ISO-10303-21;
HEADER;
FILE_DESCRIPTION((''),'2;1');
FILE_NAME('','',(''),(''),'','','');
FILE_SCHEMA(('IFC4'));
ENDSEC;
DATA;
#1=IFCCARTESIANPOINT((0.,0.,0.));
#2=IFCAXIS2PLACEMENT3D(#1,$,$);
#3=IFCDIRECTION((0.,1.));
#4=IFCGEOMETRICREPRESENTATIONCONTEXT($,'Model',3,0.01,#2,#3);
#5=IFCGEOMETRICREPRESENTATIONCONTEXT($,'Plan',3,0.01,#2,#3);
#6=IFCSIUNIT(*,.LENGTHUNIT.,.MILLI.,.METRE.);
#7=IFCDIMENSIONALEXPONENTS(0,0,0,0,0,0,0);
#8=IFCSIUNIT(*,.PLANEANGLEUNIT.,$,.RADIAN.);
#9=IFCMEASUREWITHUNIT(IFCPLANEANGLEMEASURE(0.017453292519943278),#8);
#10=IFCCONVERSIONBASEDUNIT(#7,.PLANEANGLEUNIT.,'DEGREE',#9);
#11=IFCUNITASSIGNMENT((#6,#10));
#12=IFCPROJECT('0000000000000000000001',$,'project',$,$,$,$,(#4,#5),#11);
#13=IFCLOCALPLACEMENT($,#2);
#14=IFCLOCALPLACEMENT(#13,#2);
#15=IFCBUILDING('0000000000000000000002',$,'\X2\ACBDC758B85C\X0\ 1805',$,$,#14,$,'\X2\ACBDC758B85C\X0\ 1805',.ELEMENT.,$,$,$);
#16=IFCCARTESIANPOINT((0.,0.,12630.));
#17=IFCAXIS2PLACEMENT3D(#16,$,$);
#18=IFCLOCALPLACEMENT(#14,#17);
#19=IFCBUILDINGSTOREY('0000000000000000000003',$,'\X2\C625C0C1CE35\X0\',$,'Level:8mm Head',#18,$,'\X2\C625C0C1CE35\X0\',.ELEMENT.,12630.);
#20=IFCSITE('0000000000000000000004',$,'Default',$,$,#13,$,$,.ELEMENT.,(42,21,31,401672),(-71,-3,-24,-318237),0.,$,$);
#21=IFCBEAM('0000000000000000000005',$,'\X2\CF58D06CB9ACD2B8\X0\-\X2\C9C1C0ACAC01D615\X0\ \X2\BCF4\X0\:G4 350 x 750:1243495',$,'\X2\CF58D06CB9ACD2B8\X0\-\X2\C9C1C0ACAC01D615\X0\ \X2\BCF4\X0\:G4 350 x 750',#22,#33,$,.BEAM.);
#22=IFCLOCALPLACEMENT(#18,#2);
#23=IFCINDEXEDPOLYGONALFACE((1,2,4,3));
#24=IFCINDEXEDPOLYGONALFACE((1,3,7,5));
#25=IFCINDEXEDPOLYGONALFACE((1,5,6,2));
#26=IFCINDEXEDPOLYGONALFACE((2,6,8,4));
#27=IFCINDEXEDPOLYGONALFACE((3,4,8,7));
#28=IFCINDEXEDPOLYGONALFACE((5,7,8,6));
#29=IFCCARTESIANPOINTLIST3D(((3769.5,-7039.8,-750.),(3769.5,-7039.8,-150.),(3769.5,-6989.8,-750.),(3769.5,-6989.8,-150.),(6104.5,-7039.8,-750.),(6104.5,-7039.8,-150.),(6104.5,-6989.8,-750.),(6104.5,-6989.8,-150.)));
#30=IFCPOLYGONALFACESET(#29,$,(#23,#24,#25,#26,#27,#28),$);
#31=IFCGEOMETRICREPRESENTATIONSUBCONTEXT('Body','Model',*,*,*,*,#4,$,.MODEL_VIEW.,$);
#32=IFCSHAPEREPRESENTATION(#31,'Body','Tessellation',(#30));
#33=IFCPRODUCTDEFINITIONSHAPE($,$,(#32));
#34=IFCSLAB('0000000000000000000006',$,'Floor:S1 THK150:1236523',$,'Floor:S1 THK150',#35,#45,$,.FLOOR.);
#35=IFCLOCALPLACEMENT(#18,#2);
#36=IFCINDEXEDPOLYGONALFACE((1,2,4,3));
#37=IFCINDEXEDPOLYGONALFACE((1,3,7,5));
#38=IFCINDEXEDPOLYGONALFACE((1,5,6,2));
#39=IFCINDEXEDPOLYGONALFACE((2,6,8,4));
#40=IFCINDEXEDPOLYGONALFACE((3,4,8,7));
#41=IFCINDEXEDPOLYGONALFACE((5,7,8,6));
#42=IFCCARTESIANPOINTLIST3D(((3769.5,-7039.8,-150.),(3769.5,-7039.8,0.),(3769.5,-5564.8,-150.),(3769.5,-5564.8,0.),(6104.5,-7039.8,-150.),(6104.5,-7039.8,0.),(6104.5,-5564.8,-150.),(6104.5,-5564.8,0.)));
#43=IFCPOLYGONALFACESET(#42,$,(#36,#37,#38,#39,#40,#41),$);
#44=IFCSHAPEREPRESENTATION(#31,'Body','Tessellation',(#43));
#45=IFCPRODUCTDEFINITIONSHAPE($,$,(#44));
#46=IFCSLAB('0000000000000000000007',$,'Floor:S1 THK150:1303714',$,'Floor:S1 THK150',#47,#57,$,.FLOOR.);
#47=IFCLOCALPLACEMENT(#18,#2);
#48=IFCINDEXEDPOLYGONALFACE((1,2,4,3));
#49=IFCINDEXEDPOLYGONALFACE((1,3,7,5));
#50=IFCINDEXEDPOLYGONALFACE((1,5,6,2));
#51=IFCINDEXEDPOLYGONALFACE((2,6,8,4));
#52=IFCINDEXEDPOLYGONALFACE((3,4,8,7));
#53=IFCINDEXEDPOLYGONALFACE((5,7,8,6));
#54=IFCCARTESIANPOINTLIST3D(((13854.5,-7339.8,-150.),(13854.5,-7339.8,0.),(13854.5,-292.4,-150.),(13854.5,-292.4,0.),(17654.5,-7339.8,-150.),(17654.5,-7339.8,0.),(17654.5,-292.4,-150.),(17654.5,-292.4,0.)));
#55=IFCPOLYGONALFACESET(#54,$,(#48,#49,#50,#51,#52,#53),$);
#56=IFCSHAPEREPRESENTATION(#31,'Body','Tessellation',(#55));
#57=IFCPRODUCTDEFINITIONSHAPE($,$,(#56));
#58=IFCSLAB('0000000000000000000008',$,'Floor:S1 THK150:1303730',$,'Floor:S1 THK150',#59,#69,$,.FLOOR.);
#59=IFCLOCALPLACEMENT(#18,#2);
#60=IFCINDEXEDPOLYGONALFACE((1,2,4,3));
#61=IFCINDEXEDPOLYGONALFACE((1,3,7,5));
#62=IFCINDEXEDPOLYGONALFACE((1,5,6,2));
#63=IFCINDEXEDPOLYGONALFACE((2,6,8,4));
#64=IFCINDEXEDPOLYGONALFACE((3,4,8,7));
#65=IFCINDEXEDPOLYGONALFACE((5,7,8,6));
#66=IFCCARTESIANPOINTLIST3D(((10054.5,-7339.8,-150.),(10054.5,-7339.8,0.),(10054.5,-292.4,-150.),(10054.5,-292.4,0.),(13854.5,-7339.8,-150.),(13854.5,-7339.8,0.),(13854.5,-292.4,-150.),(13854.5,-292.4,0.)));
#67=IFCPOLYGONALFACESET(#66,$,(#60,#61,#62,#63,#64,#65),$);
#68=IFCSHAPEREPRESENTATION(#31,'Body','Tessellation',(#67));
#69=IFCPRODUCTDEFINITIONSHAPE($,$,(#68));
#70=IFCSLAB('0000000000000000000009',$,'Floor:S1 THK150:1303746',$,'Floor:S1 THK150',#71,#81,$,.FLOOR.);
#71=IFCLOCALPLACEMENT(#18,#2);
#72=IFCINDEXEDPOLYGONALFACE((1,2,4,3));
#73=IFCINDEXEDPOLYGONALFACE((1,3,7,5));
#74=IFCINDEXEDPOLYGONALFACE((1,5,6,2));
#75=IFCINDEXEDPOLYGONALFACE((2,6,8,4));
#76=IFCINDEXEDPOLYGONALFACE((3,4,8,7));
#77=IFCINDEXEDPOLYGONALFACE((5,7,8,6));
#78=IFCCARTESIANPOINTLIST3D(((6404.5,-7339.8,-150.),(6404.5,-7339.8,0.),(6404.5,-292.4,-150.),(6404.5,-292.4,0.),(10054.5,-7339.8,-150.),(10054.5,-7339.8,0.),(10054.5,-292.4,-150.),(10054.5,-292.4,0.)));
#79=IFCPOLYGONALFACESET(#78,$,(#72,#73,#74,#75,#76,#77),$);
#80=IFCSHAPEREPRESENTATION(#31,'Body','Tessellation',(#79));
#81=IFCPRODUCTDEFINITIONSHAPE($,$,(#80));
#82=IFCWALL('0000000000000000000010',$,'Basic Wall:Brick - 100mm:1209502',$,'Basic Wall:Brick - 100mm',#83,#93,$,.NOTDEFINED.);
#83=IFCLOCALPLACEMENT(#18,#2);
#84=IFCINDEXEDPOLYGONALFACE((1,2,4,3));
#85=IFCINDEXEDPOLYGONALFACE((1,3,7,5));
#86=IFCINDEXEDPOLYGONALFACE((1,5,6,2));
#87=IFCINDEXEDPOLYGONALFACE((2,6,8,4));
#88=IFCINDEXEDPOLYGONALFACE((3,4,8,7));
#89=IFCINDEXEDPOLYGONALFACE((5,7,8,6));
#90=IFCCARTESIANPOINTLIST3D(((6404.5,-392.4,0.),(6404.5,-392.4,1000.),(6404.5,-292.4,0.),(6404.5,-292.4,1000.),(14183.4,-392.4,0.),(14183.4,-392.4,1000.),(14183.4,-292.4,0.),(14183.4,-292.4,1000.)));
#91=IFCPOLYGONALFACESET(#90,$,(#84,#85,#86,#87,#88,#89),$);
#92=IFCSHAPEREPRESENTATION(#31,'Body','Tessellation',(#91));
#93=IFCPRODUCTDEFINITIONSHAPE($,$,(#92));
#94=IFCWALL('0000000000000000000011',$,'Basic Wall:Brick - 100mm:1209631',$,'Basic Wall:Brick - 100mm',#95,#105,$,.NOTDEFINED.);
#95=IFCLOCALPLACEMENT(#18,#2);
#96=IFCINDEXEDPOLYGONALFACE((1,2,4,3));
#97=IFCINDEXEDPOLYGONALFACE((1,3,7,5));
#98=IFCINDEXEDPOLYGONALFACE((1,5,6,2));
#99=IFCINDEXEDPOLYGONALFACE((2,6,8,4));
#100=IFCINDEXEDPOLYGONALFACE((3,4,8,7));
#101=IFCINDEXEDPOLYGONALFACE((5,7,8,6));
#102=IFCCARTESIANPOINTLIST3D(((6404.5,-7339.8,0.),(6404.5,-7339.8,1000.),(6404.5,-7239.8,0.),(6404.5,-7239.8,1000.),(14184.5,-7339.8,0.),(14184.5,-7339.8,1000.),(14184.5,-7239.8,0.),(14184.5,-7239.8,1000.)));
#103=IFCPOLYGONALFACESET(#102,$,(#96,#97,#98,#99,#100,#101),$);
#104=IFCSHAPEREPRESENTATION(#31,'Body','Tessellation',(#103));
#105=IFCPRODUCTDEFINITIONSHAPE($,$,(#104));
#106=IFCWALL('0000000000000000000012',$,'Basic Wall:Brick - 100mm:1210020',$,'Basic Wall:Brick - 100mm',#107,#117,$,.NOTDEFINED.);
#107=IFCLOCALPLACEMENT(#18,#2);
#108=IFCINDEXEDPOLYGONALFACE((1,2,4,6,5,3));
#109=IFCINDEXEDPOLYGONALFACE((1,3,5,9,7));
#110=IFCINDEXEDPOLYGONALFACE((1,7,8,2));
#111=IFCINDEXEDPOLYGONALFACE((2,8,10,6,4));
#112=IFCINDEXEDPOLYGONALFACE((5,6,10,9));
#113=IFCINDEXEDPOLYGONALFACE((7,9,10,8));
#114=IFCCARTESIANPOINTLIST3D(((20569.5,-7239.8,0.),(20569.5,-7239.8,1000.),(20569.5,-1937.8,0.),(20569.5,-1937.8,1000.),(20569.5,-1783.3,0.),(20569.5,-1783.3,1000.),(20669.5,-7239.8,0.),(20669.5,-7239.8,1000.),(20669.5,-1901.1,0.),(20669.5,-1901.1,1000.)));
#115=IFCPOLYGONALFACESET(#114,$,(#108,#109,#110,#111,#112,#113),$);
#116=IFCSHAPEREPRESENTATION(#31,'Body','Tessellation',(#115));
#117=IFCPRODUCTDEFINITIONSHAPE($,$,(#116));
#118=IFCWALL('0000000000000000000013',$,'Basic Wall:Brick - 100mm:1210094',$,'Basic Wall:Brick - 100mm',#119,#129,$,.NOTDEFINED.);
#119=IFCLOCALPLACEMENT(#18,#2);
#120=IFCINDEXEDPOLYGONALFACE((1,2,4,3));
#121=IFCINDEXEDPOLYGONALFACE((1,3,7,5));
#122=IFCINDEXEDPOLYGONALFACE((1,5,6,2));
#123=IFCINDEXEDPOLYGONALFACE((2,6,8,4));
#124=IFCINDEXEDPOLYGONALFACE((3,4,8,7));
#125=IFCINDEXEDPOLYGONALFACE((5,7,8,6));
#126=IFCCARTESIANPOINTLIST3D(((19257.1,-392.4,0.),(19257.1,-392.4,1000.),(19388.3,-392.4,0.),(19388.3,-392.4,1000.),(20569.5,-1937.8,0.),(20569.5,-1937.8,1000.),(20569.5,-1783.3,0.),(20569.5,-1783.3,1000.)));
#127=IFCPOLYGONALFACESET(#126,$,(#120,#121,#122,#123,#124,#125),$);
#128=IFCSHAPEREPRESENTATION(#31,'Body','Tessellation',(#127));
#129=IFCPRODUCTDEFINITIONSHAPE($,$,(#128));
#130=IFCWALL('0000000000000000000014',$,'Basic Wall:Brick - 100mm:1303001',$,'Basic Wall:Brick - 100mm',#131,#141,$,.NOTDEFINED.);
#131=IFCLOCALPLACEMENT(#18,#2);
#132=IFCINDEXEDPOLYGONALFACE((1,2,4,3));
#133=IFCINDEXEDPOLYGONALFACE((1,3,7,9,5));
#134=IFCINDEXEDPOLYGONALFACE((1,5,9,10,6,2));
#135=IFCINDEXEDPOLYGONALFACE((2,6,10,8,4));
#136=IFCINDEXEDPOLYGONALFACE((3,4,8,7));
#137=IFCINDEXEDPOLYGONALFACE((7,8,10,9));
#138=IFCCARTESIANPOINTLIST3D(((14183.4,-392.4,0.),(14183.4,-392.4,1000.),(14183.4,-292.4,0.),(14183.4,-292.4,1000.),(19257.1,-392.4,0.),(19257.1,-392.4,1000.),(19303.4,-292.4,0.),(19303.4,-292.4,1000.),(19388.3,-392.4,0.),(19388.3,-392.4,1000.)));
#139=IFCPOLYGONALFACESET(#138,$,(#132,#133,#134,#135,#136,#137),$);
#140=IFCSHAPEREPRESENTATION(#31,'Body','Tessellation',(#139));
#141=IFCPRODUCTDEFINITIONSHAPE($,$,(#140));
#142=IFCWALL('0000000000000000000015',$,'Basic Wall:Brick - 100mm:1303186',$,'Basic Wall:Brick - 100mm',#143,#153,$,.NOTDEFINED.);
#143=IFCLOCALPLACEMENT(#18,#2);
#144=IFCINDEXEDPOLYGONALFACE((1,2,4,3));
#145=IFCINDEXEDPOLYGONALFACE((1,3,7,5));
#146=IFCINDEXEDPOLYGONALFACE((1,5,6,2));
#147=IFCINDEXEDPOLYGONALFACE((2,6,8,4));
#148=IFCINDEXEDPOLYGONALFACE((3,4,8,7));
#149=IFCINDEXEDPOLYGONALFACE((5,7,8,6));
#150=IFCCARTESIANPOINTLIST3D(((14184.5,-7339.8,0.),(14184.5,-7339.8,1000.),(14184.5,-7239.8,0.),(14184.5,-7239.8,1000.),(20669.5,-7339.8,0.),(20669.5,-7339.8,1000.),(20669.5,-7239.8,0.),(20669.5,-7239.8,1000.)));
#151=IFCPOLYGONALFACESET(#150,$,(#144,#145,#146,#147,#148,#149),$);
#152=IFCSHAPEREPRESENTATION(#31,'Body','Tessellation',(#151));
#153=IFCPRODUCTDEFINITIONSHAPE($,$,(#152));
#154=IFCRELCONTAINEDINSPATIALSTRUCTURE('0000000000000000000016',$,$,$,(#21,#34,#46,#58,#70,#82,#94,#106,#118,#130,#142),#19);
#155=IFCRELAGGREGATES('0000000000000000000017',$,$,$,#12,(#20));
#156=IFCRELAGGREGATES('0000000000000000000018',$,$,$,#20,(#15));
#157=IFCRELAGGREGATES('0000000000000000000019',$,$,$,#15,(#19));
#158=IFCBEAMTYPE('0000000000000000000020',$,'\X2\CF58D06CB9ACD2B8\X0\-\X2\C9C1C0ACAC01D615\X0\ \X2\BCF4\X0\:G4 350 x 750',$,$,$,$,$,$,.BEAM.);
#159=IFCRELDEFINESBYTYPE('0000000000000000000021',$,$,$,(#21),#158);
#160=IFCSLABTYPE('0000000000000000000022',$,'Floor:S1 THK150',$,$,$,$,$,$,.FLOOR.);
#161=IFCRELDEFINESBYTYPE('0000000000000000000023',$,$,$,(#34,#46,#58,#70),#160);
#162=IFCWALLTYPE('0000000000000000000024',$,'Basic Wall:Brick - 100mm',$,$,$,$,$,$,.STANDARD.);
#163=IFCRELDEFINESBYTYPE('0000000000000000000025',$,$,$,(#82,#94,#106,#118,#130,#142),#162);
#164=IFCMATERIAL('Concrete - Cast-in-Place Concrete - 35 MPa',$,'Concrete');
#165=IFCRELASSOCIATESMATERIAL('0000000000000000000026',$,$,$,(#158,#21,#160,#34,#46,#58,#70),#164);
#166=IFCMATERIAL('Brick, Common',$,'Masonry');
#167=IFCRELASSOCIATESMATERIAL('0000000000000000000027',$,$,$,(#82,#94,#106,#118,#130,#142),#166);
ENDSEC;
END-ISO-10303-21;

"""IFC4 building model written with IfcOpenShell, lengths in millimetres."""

from ifc_helpers import new_model, entity, si_unit, converted_unit, direction, frame, origin, place, context, subcontext, project, spatial, indexed_curve, outline, extrude, source, transform, mapped, material, type_object, type_shapes, element, save


model = new_model("IFC4")

# Units and contexts
model_context = context("Model", 3, precision=0.01, world=origin(), true_north=direction((0.0, 1.0)))
plan_context = context("Plan", 3, precision=0.01, world=origin(), true_north=direction((0.0, 1.0)))
body_context = subcontext(model_context, "Body", "Model", "MODEL_VIEW")
ifc_project = project(units=[si_unit("LENGTHUNIT", "METRE", prefix="MILLI"), converted_unit("PLANEANGLEUNIT", "DEGREE", entity("IfcPlaneAngleMeasure", 0.017453292519943278), si_unit("PLANEANGLEUNIT", "RADIAN"), dimensions=[0, 0, 0, 0, 0, 0, 0])], contexts=[model_context, plan_context])

# Site, building, storey
site_placement = place(None, origin())
site = spatial("IfcSite", under=ifc_project, at=site_placement, Name="Default", CompositionType="ELEMENT", RefLatitude=(42, 21, 31, 401672), RefLongitude=(-71, -3, -24, -318237), RefElevation=0.0)
building_placement = place(site_placement, origin())
building = spatial("IfcBuilding", under=site, at=building_placement, Name="경의로 1805", LongName="경의로 1805", CompositionType="ELEMENT")
storey_placement = place(building_placement, frame((0.0, 0.0, 12630.0)))
storey = spatial("IfcBuildingStorey", under=building, at=storey_placement, Name="옥상층", ObjectType="Level:8mm Head", LongName="옥상층", CompositionType="ELEMENT", Elevation=12630.0)

# Beam
ifc_material_1 = material(Name="Concrete - Cast-in-Place Concrete - 35 MPa", Category="Concrete")
beam_type = type_object("IfcBeamType", Name="콘크리트-직사각형 보:G4 350 x 750", PredefinedType="BEAM", material=ifc_material_1)
shared_shape = source(origin(), body_context, "Body", "SweptSolid", [
    extrude(outline(indexed_curve([(-300.0, -25.0), (300.0, -25.0), (300.0, 25.0), (-300.0, 25.0), (-300.0, -25.0)], self_intersect=False)), frame((3769.5, -7014.8, 12180.0), z_axis=(1.0, 0.0, 0.0), x_axis=(0.0, 0.0, -1.0)), (0.0, 0.0, 1.0), 2335.0),
])
type_shapes(beam_type, [shared_shape])
beam_placement = place(storey_placement, frame((0.0, 0.0, -12630.0)))
element("IfcBeam", 1, at=beam_placement, inside=storey, type_object=beam_type, material=ifc_material_1, Name="콘크리트-직사각형 보:G4 350 x 750:1243495", ObjectType="콘크리트-직사각형 보:G4 350 x 750", PredefinedType="BEAM", context=body_context, shape_type="MappedRepresentation", body=[
    mapped(shared_shape, transform((0.0, 0.0, 0.0), scale=1.0)),
])

# Slabs
slab_type = type_object("IfcSlabType", Name="Floor:S1 THK150", PredefinedType="FLOOR", material=ifc_material_1)
slab_1_placement = place(storey_placement, origin())
element("IfcSlab", 2, at=slab_1_placement, inside=storey, type_object=slab_type, material=ifc_material_1, Name="Floor:S1 THK150:1236523", ObjectType="Floor:S1 THK150", PredefinedType="FLOOR", context=body_context, shape_type="SweptSolid", body=[
    extrude(outline(indexed_curve([(-737.5, -1167.5), (737.5, -1167.5), (737.5, 1167.5), (-737.5, 1167.5), (-737.5, -1167.5)], self_intersect=False)), frame((4937.0, -6302.3, 0.0), z_axis=(0.0, 0.0, -1.0), x_axis=(0.0, 1.0, 0.0)), (0.0, 0.0, 1.0), 150.0),
])
slab_2_placement = place(storey_placement, origin())
element("IfcSlab", 3, at=slab_2_placement, inside=storey, type_object=slab_type, material=ifc_material_1, Name="Floor:S1 THK150:1303714", ObjectType="Floor:S1 THK150", PredefinedType="FLOOR", context=body_context, shape_type="SweptSolid", body=[
    extrude(outline(indexed_curve([(-3523.7, -1900.0), (3523.7, -1900.0), (3523.7, 1900.0), (-3523.7, 1900.0), (-3523.7, -1900.0)], self_intersect=False)), frame((15754.5, -3816.1, 0.0), z_axis=(0.0, 0.0, -1.0), x_axis=(0.0, 1.0, 0.0)), (0.0, 0.0, 1.0), 150.0),
])
slab_3_placement = place(storey_placement, origin())
element("IfcSlab", 4, at=slab_3_placement, inside=storey, type_object=slab_type, material=ifc_material_1, Name="Floor:S1 THK150:1303730", ObjectType="Floor:S1 THK150", PredefinedType="FLOOR", context=body_context, shape_type="SweptSolid", body=[
    extrude(outline(indexed_curve([(-3523.7, -1900.0), (3523.7, -1900.0), (3523.7, 1900.0), (-3523.7, 1900.0), (-3523.7, -1900.0)], self_intersect=False)), frame((11954.5, -3816.1, 0.0), z_axis=(0.0, 0.0, -1.0), x_axis=(0.0, 1.0, 0.0)), (0.0, 0.0, 1.0), 150.0),
])
slab_4_placement = place(storey_placement, origin())
element("IfcSlab", 5, at=slab_4_placement, inside=storey, type_object=slab_type, material=ifc_material_1, Name="Floor:S1 THK150:1303746", ObjectType="Floor:S1 THK150", PredefinedType="FLOOR", context=body_context, shape_type="SweptSolid", body=[
    extrude(outline(indexed_curve([(-3523.7, -1825.0), (3523.7, -1825.0), (3523.7, 1825.0), (-3523.7, 1825.0), (-3523.7, -1825.0)], self_intersect=False)), frame((8229.5, -3816.1, 0.0), z_axis=(0.0, 0.0, -1.0), x_axis=(0.0, 1.0, 0.0)), (0.0, 0.0, 1.0), 150.0),
])

# Walls
ifc_material_2 = material(Name="Brick, Common", Category="Masonry")
wall_type = type_object("IfcWallType", Name="Basic Wall:Brick - 100mm", PredefinedType="STANDARD")
wall_1_placement = place(storey_placement, frame((6404.5, -342.4, 0.0)))
element("IfcWall", 6, at=wall_1_placement, inside=storey, type_object=wall_type, material=ifc_material_2, Name="Basic Wall:Brick - 100mm:1209502", ObjectType="Basic Wall:Brick - 100mm", PredefinedType="NOTDEFINED", context=body_context, shape_type="SweptSolid", body=[
    extrude(outline(indexed_curve([(7778.9, 50.0), (0.0, 50.0), (0.0, -50.0), (7778.9, -50.0), (7778.9, 50.0)], self_intersect=False)), origin(), (0.0, 0.0, 1.0), 1000.0),
])
wall_2_placement = place(storey_placement, frame((6404.5, -7289.8, 0.0)))
element("IfcWall", 7, at=wall_2_placement, inside=storey, type_object=wall_type, material=ifc_material_2, Name="Basic Wall:Brick - 100mm:1209631", ObjectType="Basic Wall:Brick - 100mm", PredefinedType="NOTDEFINED", context=body_context, shape_type="SweptSolid", body=[
    extrude(outline(indexed_curve([(7780.0, 50.0), (0.0, 50.0), (0.0, -50.0), (7780.0, -50.0), (7780.0, 50.0)], self_intersect=False)), origin(), (0.0, 0.0, 1.0), 1000.0),
])
wall_3_placement = place(storey_placement, frame((20619.5, -7239.8, 0.0), z_axis=(0.0, 0.0, 1.0), x_axis=(0.0, 1.0, 0.0)))
element("IfcWall", 8, at=wall_3_placement, inside=storey, type_object=wall_type, material=ifc_material_2, Name="Basic Wall:Brick - 100mm:1210020", ObjectType="Basic Wall:Brick - 100mm", PredefinedType="NOTDEFINED", context=body_context, shape_type="SweptSolid", body=[
    extrude(outline(indexed_curve([(5338.8, -50.0), (5456.5, 50.0), (5302.1, 50.0), (0.0, 50.0), (0.0, -50.0), (5338.8, -50.0)], self_intersect=False)), origin(), (0.0, 0.0, 1.0), 1000.0),
])
wall_4_placement = place(storey_placement, frame((19295.3, -360.0, 0.0), z_axis=(0.0, 0.0, 1.0), x_axis=(0.647298, -0.762237, 0.0)))
element("IfcWall", 9, at=wall_4_placement, inside=storey, type_object=wall_type, material=ifc_material_2, Name="Basic Wall:Brick - 100mm:1210094", ObjectType="Basic Wall:Brick - 100mm", PredefinedType="NOTDEFINED", context=body_context, shape_type="SweptSolid", body=[
    extrude(outline(indexed_curve([(2027.4, -50.0), (1909.7, 50.0), (84.9, 50.0), (0.0, -50.0), (2027.4, -50.0)], self_intersect=False)), origin(), (0.0, 0.0, 1.0), 1000.0),
])
wall_5_placement = place(storey_placement, frame((14183.4, -342.4, 0.0)))
element("IfcWall", 10, at=wall_5_placement, inside=storey, type_object=wall_type, material=ifc_material_2, Name="Basic Wall:Brick - 100mm:1303001", ObjectType="Basic Wall:Brick - 100mm", PredefinedType="NOTDEFINED", context=body_context, shape_type="SweptSolid", body=[
    extrude(outline(indexed_curve([(5204.9, -50.0), (5120.0, 50.0), (0.0, 50.0), (0.0, -50.0), (5073.7, -50.0), (5204.9, -50.0)], self_intersect=False)), origin(), (0.0, 0.0, 1.0), 1000.0),
])
wall_6_placement = place(storey_placement, frame((14184.5, -7289.8, 0.0)))
element("IfcWall", 11, at=wall_6_placement, inside=storey, type_object=wall_type, material=ifc_material_2, Name="Basic Wall:Brick - 100mm:1303186", ObjectType="Basic Wall:Brick - 100mm", PredefinedType="NOTDEFINED", context=body_context, shape_type="SweptSolid", body=[
    extrude(outline(indexed_curve([(6485.0, 50.0), (0.0, 50.0), (0.0, -50.0), (6485.0, -50.0), (6485.0, 50.0)], self_intersect=False)), origin(), (0.0, 0.0, 1.0), 1000.0),
])

save(model, "model.ifc")
